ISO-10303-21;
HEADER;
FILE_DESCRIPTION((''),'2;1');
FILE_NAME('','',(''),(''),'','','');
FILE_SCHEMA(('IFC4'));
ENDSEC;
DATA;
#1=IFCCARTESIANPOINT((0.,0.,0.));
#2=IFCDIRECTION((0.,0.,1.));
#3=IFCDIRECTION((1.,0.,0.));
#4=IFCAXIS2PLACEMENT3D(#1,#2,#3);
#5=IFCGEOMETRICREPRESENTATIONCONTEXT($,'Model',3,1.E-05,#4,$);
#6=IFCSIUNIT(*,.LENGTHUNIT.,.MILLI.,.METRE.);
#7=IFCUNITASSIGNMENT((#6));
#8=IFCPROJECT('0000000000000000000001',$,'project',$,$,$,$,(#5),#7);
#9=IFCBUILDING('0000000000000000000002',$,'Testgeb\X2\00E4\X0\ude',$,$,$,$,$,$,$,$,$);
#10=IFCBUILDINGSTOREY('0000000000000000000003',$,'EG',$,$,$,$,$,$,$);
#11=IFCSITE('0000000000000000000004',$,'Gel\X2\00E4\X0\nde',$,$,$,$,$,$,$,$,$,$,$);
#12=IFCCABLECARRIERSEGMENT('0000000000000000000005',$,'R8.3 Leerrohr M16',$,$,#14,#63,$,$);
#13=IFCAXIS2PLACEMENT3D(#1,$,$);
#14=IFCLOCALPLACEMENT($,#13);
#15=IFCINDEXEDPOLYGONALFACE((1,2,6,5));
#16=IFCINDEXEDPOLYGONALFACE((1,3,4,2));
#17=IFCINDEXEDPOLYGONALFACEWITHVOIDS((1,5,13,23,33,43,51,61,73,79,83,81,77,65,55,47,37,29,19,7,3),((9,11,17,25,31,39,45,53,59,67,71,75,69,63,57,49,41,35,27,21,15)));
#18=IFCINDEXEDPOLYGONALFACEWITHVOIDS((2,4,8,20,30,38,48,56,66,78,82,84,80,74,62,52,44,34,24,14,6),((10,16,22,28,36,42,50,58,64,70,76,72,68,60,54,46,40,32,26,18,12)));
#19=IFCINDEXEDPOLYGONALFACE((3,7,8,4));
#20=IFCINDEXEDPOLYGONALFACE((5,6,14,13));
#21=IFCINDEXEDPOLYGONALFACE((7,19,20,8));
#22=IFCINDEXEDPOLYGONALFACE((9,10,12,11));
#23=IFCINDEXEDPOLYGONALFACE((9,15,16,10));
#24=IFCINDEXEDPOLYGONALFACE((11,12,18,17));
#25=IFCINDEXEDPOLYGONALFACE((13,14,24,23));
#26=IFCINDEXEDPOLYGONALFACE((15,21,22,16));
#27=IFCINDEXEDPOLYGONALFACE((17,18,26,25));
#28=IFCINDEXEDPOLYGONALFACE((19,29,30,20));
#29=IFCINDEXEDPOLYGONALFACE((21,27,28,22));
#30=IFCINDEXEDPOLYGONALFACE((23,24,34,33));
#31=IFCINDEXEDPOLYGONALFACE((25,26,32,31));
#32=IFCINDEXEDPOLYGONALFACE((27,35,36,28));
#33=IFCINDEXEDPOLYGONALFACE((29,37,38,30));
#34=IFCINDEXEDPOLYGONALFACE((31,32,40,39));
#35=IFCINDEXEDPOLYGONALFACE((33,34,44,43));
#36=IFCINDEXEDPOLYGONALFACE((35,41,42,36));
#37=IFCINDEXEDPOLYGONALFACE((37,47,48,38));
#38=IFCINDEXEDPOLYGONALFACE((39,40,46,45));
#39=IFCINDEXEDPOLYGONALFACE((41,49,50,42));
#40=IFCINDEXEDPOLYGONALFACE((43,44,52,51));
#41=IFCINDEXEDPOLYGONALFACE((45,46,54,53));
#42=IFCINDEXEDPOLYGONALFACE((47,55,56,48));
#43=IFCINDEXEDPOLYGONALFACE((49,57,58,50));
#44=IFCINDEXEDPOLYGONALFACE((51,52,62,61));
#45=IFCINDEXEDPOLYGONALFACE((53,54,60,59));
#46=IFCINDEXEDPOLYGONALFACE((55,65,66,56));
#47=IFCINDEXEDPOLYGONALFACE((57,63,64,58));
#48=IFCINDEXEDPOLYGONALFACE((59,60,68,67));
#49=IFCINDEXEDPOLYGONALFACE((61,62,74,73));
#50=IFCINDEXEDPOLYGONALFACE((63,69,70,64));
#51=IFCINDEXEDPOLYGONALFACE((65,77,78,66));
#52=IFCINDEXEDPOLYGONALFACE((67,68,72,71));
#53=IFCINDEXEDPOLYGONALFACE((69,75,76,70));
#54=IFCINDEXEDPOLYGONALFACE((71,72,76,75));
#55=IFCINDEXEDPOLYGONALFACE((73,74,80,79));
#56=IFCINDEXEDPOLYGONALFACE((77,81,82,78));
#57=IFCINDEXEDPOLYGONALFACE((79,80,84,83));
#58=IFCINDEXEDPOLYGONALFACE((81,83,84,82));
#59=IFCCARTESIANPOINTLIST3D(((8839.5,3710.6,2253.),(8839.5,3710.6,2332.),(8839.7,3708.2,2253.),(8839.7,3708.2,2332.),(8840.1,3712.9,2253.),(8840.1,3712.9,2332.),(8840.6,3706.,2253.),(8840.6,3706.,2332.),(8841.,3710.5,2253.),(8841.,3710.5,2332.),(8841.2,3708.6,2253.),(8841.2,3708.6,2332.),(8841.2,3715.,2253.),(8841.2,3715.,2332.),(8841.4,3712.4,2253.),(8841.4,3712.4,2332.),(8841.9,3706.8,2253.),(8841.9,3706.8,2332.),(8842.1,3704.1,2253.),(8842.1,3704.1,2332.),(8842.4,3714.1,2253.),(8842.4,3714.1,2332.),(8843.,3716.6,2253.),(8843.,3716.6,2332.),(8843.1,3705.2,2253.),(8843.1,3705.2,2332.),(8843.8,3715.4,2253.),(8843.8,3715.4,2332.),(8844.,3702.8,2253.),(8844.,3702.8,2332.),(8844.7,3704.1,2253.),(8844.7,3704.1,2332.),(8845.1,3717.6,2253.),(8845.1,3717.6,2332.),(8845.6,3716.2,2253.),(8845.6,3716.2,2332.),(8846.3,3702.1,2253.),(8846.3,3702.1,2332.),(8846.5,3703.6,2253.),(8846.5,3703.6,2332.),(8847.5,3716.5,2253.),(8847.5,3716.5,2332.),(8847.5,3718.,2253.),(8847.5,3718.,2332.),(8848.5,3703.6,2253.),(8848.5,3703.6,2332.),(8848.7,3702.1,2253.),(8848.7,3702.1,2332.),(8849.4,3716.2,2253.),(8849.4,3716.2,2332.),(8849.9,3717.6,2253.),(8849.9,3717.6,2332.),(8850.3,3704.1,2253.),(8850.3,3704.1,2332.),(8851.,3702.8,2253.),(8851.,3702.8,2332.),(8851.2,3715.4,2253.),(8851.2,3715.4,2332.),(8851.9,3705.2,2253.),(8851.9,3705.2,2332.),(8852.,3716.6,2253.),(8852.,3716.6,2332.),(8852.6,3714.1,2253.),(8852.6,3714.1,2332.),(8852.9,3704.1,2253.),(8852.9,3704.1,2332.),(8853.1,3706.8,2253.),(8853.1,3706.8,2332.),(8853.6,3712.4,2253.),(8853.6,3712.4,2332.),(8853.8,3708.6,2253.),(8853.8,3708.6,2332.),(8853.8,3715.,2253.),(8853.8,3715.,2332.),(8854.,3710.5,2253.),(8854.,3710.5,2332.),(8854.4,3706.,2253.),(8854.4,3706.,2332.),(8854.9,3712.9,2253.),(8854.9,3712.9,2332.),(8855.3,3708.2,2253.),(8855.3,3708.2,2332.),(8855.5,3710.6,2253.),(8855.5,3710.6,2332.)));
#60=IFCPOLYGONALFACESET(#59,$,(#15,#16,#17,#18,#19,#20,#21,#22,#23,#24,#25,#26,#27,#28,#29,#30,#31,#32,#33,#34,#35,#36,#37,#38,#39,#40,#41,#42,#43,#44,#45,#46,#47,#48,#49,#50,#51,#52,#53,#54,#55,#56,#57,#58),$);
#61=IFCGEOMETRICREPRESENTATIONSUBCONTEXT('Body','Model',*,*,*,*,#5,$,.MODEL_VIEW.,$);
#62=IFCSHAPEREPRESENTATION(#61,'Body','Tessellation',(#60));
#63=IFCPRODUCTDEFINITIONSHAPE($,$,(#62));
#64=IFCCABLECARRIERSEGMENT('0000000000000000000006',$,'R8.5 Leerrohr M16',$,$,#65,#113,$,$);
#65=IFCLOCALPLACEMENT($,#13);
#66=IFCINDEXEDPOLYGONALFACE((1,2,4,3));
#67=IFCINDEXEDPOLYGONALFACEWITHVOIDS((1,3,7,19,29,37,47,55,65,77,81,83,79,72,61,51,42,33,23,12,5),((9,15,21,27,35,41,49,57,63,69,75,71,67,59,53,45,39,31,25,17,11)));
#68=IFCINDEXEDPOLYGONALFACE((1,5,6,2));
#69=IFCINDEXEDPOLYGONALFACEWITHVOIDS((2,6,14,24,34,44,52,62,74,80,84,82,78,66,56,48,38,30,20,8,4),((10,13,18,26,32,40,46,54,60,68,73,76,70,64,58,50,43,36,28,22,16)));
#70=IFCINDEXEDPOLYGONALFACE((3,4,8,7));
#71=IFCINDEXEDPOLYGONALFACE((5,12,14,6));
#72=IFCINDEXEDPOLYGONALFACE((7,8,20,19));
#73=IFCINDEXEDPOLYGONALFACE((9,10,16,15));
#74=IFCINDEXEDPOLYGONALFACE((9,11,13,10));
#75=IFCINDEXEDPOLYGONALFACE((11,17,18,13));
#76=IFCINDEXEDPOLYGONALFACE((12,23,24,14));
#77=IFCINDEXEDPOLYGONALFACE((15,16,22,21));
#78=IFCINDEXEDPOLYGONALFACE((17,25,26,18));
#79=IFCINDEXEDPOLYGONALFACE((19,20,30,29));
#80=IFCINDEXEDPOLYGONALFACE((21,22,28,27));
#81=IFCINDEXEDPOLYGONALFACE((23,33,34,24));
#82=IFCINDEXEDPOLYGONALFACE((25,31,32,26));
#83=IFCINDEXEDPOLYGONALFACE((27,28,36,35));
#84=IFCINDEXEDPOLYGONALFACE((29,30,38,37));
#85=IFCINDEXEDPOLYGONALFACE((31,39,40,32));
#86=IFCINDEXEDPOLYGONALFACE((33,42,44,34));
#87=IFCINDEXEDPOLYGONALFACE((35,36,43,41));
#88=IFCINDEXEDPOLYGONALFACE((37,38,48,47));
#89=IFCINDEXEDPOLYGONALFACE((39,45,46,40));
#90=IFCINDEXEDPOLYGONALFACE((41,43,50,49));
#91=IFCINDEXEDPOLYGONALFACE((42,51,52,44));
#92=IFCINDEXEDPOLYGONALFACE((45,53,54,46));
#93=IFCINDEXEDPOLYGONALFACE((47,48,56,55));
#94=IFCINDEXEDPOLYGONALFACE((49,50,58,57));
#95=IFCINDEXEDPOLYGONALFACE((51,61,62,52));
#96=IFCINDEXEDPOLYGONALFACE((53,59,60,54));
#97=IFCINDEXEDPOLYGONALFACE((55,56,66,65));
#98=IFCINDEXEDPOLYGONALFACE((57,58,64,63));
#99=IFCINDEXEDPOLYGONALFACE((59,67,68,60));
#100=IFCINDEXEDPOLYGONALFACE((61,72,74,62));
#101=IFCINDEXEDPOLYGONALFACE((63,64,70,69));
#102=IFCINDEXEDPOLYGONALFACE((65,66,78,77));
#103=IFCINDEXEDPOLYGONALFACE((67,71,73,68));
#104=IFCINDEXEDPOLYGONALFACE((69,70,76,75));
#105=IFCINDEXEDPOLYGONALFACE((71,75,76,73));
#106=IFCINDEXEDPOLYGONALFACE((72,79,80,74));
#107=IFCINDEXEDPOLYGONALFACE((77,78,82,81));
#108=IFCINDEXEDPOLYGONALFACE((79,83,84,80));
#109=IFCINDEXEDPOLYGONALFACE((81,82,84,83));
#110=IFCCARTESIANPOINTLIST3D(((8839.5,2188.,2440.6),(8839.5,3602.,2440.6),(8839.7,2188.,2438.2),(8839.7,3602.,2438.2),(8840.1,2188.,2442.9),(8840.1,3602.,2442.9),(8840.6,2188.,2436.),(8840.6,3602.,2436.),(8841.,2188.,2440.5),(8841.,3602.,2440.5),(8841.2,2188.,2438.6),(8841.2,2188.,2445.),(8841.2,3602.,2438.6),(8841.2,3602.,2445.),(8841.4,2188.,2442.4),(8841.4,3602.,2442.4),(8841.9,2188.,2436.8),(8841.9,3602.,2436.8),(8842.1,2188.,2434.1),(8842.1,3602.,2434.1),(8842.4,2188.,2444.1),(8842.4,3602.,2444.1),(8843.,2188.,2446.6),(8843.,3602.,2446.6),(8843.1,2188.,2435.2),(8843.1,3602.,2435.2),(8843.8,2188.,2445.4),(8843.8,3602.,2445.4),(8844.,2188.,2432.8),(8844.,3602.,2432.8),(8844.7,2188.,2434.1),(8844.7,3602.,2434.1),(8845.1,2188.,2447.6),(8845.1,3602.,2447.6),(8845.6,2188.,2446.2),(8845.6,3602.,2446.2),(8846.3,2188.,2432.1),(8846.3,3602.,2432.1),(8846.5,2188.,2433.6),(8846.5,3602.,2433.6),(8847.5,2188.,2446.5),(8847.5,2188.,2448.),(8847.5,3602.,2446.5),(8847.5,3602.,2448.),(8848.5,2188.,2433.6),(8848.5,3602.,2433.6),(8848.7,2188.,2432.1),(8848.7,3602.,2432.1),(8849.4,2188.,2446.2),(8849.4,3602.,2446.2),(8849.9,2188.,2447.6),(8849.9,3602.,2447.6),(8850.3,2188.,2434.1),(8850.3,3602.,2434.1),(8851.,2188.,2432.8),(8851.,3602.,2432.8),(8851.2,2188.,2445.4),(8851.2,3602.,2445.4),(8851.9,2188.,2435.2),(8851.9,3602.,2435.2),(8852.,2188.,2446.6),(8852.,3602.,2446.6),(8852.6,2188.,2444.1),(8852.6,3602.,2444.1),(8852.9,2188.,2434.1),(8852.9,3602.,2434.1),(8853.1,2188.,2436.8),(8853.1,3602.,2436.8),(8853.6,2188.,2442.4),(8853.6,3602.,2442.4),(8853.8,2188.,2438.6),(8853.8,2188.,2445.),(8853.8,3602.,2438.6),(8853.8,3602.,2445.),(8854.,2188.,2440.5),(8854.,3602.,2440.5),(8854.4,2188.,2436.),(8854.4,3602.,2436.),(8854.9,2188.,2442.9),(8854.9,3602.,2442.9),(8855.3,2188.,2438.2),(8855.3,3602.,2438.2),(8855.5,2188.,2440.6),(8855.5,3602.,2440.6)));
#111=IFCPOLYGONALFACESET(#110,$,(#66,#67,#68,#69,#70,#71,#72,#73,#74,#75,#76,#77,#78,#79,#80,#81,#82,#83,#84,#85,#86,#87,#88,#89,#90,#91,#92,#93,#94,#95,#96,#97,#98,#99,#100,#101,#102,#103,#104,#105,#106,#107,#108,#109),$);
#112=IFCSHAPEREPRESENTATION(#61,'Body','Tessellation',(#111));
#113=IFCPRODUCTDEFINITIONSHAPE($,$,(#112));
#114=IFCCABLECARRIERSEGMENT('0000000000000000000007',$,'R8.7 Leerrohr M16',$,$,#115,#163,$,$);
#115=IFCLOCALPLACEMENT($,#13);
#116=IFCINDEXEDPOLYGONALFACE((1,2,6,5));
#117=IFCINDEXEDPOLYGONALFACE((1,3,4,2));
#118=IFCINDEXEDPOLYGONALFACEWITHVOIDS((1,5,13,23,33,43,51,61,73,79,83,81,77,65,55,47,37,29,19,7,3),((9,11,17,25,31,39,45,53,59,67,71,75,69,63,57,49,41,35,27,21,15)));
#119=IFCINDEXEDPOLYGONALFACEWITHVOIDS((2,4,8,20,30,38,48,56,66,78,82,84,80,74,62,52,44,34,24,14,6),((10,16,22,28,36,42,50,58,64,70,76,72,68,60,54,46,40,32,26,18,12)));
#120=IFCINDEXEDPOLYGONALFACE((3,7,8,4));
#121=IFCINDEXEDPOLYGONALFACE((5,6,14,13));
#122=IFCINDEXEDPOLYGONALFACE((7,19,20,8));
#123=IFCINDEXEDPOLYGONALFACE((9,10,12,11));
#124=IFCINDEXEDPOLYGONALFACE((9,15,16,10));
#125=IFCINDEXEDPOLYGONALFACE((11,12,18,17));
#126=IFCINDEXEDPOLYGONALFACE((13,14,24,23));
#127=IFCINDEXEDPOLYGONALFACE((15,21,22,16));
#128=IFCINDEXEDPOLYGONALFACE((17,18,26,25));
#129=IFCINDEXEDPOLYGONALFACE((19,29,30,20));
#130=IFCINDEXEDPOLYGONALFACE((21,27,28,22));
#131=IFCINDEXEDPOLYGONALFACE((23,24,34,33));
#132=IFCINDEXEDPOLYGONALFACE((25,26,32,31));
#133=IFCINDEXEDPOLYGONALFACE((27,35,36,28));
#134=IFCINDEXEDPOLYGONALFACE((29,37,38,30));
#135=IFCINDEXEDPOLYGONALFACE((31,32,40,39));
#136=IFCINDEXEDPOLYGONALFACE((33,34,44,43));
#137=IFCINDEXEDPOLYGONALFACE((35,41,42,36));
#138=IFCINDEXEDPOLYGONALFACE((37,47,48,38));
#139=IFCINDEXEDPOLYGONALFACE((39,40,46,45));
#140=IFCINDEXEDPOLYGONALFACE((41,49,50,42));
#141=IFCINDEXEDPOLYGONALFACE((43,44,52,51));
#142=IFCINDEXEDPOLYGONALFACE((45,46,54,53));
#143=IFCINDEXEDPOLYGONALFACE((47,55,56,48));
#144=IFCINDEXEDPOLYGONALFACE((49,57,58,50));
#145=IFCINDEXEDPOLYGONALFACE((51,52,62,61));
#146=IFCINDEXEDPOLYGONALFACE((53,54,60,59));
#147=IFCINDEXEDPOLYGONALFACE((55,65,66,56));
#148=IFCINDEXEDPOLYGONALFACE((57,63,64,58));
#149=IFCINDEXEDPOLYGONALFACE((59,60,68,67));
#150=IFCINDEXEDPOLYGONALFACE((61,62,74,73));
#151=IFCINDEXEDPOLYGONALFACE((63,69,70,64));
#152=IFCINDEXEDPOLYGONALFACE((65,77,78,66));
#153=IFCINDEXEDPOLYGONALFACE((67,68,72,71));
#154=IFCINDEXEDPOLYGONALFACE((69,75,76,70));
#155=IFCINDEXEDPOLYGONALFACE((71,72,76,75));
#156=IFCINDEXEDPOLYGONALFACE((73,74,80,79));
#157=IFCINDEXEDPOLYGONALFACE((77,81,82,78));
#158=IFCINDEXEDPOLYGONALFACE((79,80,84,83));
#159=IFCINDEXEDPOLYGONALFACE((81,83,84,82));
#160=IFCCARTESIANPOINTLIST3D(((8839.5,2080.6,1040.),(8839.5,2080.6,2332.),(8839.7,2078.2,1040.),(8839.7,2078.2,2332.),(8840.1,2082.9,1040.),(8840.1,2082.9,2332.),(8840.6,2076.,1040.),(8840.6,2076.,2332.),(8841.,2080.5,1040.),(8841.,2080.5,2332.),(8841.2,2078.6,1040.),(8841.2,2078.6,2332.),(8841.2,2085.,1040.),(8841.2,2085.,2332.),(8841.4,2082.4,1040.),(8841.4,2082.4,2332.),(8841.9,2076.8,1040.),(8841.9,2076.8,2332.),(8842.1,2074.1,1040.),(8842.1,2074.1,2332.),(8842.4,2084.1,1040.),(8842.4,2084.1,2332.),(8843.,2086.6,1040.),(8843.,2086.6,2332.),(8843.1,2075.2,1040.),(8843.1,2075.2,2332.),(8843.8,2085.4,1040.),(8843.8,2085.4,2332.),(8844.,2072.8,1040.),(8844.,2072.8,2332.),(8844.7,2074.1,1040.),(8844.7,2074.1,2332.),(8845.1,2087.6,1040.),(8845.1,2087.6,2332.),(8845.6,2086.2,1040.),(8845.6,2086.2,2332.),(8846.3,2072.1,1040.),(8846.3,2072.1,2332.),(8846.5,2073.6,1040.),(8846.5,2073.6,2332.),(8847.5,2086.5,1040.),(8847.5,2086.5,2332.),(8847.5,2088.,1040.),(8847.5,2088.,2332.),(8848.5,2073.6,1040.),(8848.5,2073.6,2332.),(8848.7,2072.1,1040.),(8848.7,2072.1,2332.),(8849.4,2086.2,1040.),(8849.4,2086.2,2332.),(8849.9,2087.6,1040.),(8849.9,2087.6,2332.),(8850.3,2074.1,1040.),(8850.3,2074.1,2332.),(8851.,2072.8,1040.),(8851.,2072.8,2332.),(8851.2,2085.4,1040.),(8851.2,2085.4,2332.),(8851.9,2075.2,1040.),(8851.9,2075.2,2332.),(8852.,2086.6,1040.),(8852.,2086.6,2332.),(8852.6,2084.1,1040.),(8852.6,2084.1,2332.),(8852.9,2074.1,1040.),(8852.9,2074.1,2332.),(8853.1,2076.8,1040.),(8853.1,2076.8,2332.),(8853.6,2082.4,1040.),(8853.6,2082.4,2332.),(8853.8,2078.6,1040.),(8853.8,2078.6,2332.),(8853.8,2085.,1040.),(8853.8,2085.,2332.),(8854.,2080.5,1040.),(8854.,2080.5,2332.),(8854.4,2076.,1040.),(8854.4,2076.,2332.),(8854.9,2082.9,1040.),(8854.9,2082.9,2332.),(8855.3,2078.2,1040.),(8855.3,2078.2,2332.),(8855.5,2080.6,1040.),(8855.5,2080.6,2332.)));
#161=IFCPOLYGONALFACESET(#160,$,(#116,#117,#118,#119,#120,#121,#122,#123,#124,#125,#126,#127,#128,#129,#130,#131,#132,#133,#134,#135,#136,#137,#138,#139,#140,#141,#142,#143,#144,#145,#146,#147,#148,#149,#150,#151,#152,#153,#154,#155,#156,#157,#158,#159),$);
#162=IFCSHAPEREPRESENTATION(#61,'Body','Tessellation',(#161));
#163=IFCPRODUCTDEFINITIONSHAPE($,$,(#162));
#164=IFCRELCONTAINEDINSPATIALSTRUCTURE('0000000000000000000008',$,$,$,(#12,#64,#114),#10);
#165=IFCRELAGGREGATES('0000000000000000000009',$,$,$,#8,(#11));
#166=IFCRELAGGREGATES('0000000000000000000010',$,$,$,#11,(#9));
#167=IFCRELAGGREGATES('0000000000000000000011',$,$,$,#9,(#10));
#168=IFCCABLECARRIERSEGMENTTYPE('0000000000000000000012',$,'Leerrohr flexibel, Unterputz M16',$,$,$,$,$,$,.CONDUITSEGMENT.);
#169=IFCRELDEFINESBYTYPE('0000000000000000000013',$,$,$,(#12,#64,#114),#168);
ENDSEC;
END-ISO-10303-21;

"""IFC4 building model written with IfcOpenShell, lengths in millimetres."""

from ifc_helpers import new_model, si_unit, frame, origin_with_axes, place, context, subcontext, project, spatial, hollow_circle, extrude, type_object, element, save


model = new_model("IFC4")

# Units and contexts
model_context = context("Model", 3, precision=1e-05, world=origin_with_axes())
body_context = subcontext(model_context, "Body", "Model", "MODEL_VIEW")
ifc_project = project(units=[si_unit("LENGTHUNIT", "METRE", prefix="MILLI")], contexts=[model_context])

# Site, building, storey
site = spatial("IfcSite", under=ifc_project, Name="Gelände")
building = spatial("IfcBuilding", under=site, Name="Testgebäude")
storey = spatial("IfcBuildingStorey", under=building, Name="EG")

# Cable carrier segments
cable_carrier_segment_type_1 = type_object("IfcCableCarrierSegmentType", Name="Leerrohr flexibel, Unterputz M16", PredefinedType="CONDUITSEGMENT")
cable_carrier_segment_1_placement = place(None, frame((8847.5, 3710.0, 2253.0), z_axis=(0.0, 0.0, 1.0), x_axis=(0.0, 1.0, 0.0)))
element("IfcCableCarrierSegment", 1, at=cable_carrier_segment_1_placement, inside=storey, type_object=cable_carrier_segment_type_1, Name="R8.3 Leerrohr M16", context=body_context, shape_type="SweptSolid", body=[
    extrude(hollow_circle(Radius=8.0, WallThickness=1.5), None, (0.0, 0.0, 1.0), 79.0),
])
cable_carrier_segment_2_placement = place(None, frame((8847.5, 3602.0, 2440.0), z_axis=(0.0, -1.0, 0.0), x_axis=(0.0, 0.0, 1.0)))
element("IfcCableCarrierSegment", 2, at=cable_carrier_segment_2_placement, inside=storey, type_object=cable_carrier_segment_type_1, Name="R8.5 Leerrohr M16", context=body_context, shape_type="SweptSolid", body=[
    extrude(hollow_circle(Radius=8.0, WallThickness=1.5), None, (0.0, 0.0, 1.0), 1414.0),
])
cable_carrier_segment_3_placement = place(None, frame((8847.5, 2080.0, 2332.0), z_axis=(0.0, 0.0, -1.0), x_axis=(0.0, 1.0, 0.0)))
element("IfcCableCarrierSegment", 3, at=cable_carrier_segment_3_placement, inside=storey, type_object=cable_carrier_segment_type_1, Name="R8.7 Leerrohr M16", context=body_context, shape_type="SweptSolid", body=[
    extrude(hollow_circle(Radius=8.0, WallThickness=1.5), None, (0.0, 0.0, 1.0), 1292.0),
])

save(model, "model.ifc")
